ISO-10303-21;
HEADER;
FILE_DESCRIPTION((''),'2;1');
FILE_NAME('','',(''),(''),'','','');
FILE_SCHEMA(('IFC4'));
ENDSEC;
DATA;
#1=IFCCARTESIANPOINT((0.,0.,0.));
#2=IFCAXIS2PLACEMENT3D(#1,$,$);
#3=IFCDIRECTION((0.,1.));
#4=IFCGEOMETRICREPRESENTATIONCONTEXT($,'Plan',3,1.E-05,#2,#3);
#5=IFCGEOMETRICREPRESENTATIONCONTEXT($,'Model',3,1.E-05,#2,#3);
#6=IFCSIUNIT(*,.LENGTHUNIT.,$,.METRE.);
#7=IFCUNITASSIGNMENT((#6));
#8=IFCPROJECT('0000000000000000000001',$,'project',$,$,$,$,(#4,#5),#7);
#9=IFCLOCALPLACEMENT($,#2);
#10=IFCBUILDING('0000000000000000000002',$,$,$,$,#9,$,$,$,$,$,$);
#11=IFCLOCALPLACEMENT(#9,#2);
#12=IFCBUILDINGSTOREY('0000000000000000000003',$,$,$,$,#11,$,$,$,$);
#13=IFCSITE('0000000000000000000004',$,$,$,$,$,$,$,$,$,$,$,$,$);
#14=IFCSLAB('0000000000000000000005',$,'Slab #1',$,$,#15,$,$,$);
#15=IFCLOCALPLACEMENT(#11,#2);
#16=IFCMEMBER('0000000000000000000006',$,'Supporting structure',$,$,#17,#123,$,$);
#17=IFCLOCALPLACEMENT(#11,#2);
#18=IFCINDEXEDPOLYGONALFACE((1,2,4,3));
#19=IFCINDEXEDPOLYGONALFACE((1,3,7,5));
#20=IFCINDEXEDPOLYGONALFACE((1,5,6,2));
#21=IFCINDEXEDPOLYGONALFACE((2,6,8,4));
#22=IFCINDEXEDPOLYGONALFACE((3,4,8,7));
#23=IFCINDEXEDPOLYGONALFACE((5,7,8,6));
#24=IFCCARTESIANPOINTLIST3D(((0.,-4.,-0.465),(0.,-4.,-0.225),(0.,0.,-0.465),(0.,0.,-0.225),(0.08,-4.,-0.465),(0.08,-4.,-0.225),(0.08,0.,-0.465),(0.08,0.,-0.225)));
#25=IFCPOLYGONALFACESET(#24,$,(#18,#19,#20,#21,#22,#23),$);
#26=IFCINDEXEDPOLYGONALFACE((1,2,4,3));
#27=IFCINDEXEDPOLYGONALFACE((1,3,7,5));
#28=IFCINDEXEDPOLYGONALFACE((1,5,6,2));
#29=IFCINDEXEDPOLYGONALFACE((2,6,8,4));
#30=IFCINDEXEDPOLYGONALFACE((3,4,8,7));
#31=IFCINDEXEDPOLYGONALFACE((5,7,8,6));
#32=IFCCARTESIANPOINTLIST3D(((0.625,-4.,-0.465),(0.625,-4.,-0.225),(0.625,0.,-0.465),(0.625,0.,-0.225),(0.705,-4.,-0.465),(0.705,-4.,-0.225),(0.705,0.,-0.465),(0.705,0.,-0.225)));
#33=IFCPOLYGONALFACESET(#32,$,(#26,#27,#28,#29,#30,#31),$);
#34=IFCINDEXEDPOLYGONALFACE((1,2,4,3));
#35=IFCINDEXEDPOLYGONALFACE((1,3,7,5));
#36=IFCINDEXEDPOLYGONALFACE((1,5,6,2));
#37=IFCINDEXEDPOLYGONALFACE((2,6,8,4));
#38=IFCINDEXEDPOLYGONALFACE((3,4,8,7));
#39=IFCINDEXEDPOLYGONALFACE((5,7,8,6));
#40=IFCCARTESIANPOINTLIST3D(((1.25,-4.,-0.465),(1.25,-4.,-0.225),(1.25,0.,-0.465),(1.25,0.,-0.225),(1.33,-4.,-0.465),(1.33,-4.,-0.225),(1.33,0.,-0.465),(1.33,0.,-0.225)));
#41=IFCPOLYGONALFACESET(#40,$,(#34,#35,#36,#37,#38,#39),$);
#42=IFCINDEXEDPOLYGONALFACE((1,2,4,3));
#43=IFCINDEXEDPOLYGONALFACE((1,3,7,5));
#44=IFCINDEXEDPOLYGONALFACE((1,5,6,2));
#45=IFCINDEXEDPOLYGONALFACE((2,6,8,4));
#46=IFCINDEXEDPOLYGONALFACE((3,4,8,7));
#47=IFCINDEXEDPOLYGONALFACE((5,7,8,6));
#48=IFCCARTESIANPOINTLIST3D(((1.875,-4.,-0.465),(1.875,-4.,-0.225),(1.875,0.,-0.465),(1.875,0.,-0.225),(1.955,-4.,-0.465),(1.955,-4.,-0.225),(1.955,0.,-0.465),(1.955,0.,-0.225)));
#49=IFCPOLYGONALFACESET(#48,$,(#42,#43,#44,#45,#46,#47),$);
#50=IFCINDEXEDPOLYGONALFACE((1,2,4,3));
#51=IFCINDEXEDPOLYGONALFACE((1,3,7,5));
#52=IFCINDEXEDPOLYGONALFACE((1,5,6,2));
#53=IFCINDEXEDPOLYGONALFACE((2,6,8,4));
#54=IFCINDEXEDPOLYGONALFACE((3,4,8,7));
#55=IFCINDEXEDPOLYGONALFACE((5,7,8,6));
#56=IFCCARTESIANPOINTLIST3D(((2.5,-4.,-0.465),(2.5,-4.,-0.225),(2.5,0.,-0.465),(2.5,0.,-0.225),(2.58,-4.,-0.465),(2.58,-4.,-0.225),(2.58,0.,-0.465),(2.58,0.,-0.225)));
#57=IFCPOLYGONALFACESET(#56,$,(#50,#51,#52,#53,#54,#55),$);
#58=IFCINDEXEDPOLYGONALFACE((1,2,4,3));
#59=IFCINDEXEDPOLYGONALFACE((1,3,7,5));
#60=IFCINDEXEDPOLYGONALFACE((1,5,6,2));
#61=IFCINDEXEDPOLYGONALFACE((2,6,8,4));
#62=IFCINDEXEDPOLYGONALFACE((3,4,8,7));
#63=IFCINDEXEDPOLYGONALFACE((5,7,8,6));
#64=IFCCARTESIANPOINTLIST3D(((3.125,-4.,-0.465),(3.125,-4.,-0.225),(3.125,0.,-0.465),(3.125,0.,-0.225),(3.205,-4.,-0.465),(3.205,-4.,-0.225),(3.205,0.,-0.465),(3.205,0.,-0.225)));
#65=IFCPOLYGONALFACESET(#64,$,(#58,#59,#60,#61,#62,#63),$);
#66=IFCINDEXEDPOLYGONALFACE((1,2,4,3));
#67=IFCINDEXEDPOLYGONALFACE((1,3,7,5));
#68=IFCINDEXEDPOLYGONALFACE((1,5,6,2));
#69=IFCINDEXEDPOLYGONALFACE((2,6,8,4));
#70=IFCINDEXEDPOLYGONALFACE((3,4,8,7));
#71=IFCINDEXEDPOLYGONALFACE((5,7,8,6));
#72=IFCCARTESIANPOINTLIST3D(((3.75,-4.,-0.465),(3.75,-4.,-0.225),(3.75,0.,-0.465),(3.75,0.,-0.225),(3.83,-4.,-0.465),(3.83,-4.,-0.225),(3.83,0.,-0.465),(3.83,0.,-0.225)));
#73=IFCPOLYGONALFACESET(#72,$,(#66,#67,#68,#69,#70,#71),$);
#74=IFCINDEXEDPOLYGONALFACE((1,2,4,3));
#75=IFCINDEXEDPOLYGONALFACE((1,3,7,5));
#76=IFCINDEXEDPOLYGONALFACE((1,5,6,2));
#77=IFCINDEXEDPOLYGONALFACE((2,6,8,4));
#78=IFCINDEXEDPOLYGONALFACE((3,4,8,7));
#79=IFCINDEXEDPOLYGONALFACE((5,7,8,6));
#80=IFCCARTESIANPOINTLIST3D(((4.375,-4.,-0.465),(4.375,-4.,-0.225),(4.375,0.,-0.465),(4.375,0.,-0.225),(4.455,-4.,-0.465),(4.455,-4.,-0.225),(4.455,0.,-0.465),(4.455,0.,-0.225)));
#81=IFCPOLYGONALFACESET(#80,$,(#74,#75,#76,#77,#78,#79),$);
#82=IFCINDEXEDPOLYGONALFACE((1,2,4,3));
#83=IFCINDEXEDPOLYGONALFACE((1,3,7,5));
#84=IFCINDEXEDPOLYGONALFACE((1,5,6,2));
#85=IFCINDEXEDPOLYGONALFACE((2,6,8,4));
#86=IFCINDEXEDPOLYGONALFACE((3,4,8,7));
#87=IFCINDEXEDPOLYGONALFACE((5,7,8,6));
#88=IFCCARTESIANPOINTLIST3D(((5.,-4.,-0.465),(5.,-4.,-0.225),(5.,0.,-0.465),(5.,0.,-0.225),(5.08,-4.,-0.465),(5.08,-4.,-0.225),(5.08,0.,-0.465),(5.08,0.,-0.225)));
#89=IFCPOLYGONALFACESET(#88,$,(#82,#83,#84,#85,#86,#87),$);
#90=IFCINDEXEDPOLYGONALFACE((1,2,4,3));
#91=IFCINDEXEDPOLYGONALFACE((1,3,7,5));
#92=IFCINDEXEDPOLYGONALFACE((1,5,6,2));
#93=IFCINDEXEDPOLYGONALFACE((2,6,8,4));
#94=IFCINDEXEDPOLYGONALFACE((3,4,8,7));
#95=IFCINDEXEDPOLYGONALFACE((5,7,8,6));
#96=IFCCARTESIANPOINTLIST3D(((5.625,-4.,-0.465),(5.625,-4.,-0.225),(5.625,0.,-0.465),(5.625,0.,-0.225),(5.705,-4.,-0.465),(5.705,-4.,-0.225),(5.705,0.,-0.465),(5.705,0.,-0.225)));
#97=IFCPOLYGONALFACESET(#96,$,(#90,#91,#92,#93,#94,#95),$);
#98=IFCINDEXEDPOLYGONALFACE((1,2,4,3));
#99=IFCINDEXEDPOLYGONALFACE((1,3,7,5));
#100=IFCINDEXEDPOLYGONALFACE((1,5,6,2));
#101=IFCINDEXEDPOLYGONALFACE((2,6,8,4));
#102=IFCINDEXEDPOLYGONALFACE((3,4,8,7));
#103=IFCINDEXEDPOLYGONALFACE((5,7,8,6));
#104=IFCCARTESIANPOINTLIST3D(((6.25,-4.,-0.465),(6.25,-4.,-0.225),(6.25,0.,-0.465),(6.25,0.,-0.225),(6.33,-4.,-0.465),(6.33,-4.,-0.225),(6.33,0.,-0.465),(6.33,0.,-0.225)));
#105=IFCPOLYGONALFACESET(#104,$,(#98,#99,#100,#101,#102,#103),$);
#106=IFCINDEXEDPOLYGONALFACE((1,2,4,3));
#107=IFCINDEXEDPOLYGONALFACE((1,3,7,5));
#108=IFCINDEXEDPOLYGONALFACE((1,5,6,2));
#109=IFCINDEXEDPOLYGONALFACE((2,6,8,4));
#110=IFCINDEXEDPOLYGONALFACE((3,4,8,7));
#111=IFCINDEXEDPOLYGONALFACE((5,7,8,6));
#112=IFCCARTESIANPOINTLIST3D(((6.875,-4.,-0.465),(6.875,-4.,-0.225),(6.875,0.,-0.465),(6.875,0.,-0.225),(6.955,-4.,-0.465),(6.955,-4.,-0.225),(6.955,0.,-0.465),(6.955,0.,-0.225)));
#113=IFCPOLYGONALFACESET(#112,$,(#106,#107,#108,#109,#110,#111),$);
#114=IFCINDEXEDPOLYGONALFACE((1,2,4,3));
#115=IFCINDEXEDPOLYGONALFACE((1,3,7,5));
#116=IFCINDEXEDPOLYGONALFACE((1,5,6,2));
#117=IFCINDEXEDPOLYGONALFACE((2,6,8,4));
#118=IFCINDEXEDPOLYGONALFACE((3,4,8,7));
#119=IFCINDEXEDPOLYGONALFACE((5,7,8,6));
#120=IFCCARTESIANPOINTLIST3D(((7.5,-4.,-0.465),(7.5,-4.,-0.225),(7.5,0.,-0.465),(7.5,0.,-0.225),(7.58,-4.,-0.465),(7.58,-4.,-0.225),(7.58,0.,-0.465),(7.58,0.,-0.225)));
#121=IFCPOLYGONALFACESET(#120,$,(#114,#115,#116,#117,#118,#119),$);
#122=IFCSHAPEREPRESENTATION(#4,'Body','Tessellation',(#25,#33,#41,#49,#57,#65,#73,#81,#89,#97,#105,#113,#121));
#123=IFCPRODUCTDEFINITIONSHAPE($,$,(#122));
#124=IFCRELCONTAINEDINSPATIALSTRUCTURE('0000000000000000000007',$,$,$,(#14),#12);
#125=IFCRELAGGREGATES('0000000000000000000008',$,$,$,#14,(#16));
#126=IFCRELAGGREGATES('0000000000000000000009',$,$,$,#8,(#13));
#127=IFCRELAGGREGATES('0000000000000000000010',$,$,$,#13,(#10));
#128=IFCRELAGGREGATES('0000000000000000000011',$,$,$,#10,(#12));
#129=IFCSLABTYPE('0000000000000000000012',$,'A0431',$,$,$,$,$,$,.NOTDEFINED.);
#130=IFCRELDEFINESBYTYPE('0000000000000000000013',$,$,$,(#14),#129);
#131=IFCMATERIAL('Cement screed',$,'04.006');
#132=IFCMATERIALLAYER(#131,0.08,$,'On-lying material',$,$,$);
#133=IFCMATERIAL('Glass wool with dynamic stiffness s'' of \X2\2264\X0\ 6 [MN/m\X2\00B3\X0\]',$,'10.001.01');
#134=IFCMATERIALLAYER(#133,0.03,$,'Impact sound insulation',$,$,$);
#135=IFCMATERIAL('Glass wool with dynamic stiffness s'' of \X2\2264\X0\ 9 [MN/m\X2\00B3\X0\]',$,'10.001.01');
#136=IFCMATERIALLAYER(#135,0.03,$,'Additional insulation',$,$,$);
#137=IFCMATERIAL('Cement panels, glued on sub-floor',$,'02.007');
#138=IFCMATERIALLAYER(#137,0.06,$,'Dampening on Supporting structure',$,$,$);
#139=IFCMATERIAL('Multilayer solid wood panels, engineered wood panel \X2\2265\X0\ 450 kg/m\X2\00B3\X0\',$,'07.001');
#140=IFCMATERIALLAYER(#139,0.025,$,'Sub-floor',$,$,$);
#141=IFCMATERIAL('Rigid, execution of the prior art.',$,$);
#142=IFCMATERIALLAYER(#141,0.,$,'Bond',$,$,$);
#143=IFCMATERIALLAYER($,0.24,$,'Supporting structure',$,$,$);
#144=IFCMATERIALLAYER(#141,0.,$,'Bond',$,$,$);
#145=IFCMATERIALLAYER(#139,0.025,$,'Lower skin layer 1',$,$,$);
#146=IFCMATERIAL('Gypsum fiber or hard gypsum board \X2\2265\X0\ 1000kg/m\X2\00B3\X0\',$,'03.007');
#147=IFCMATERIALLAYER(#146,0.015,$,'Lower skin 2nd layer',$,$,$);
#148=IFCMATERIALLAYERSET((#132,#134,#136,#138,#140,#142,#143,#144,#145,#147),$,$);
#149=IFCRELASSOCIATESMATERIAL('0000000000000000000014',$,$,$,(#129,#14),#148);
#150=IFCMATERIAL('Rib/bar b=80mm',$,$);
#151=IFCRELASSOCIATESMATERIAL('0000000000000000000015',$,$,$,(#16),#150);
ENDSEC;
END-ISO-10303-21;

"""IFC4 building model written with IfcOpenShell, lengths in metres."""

from ifc_helpers import new_model, si_unit, direction, frame, frame_2d, origin, place, context, project, spatial, rectangle, extrude, material, layer, layer_set, type_object, element, aggregate, save


model = new_model("IFC4")

# Units and contexts
plan_context = context("Plan", 3, precision=1e-05, world=origin(), true_north=direction((0.0, 1.0)))
model_context = context("Model", 3, precision=1e-05, world=origin(), true_north=direction((0.0, 1.0)))
ifc_project = project(units=[si_unit("LENGTHUNIT", "METRE")], contexts=[plan_context, model_context])

# Site, building, storey
site = spatial("IfcSite", under=ifc_project)
building_placement = place(None, origin())
building = spatial("IfcBuilding", under=site, at=building_placement)
storey_placement = place(building_placement, origin())
storey = spatial("IfcBuildingStorey", under=building, at=storey_placement)

# Slab, member
ifc_material_1 = material(Name="Cement screed", Category="04.006")
ifc_layer_1 = layer(ifc_material_1, 0.08, Name="On-lying material")
ifc_material_2 = material(Name="Glass wool with dynamic stiffness s' of ≤ 6 [MN/m³]", Category="10.001.01")
ifc_layer_2 = layer(ifc_material_2, 0.03, Name="Impact sound insulation")
ifc_material_3 = material(Name="Glass wool with dynamic stiffness s' of ≤ 9 [MN/m³]", Category="10.001.01")
ifc_layer_3 = layer(ifc_material_3, 0.03, Name="Additional insulation")
ifc_material_4 = material(Name="Cement panels, glued on sub-floor", Category="02.007")
ifc_layer_4 = layer(ifc_material_4, 0.06, Name="Dampening on Supporting structure")
ifc_material_5 = material(Name="Multilayer solid wood panels, engineered wood panel ≥ 450 kg/m³", Category="07.001")
ifc_layer_5 = layer(ifc_material_5, 0.025, Name="Sub-floor")
ifc_material_6 = material(Name="Rigid, execution of the prior art.")
ifc_layer_6 = layer(ifc_material_6, 0.0, Name="Bond")
ifc_layer_7 = layer(None, 0.24, Name="Supporting structure")
ifc_layer_8 = layer(ifc_material_6, 0.0, Name="Bond")
ifc_layer_9 = layer(ifc_material_5, 0.025, Name="Lower skin layer 1")
ifc_material_7 = material(Name="Gypsum fiber or hard gypsum board ≥ 1000kg/m³", Category="03.007")
ifc_layer_10 = layer(ifc_material_7, 0.015, Name="Lower skin 2nd layer")
ifc_layer_set = layer_set([ifc_layer_1, ifc_layer_2, ifc_layer_3, ifc_layer_4, ifc_layer_5, ifc_layer_6, ifc_layer_7, ifc_layer_8, ifc_layer_9, ifc_layer_10])
slab_type = type_object("IfcSlabType", Name="A0431", PredefinedType="NOTDEFINED", material=ifc_layer_set)
slab_placement = place(None, frame((0.0, 0.0, 0.0), z_axis=(0.0, 0.0, -1.0), x_axis=(1.0, 0.0, 0.0)))
slab = element("IfcSlab", 1, at=slab_placement, inside=storey, type_object=slab_type, material=ifc_layer_set, Name="Slab #1")
ifc_material_8 = material(Name="Rib/bar b=80mm")
member_1_placement = place(slab_placement, origin())
member_1 = element("IfcMember", 2, at=member_1_placement, material=ifc_material_8, Name="Supporting structure", context=plan_context, shape_type="SweptSolid", body=[
    extrude(rectangle(XDim=0.08, YDim=0.24, at=frame_2d((0.04, 0.12), x_axis=(1.0, 0.0))), frame((0.0, 4.0, 0.225), z_axis=(0.0, -1.0, 0.0), x_axis=(1.0, 0.0, 0.0)), (0.0, 0.0, 1.0), 4.0),
    extrude(rectangle(XDim=0.08, YDim=0.24, at=frame_2d((0.04, 0.12), x_axis=(1.0, 0.0))), frame((0.625, 4.0, 0.225), z_axis=(0.0, -1.0, 0.0), x_axis=(1.0, 0.0, 0.0)), (0.0, 0.0, 1.0), 4.0),
    extrude(rectangle(XDim=0.08, YDim=0.24, at=frame_2d((0.04, 0.12), x_axis=(1.0, 0.0))), frame((1.25, 4.0, 0.225), z_axis=(0.0, -1.0, 0.0), x_axis=(1.0, 0.0, 0.0)), (0.0, 0.0, 1.0), 4.0),
    extrude(rectangle(XDim=0.08, YDim=0.24, at=frame_2d((0.04, 0.12), x_axis=(1.0, 0.0))), frame((1.875, 4.0, 0.225), z_axis=(0.0, -1.0, 0.0), x_axis=(1.0, 0.0, 0.0)), (0.0, 0.0, 1.0), 4.0),
    extrude(rectangle(XDim=0.08, YDim=0.24, at=frame_2d((0.04, 0.12), x_axis=(1.0, 0.0))), frame((2.5, 4.0, 0.225), z_axis=(0.0, -1.0, 0.0), x_axis=(1.0, 0.0, 0.0)), (0.0, 0.0, 1.0), 4.0),
    extrude(rectangle(XDim=0.08, YDim=0.24, at=frame_2d((0.04, 0.12), x_axis=(1.0, 0.0))), frame((3.125, 4.0, 0.225), z_axis=(0.0, -1.0, 0.0), x_axis=(1.0, 0.0, 0.0)), (0.0, 0.0, 1.0), 4.0),
    extrude(rectangle(XDim=0.08, YDim=0.24, at=frame_2d((0.04, 0.12), x_axis=(1.0, 0.0))), frame((3.75, 4.0, 0.225), z_axis=(0.0, -1.0, 0.0), x_axis=(1.0, 0.0, 0.0)), (0.0, 0.0, 1.0), 4.0),
    extrude(rectangle(XDim=0.08, YDim=0.24, at=frame_2d((0.04, 0.12), x_axis=(1.0, 0.0))), frame((4.375, 4.0, 0.225), z_axis=(0.0, -1.0, 0.0), x_axis=(1.0, 0.0, 0.0)), (0.0, 0.0, 1.0), 4.0),
    extrude(rectangle(XDim=0.08, YDim=0.24, at=frame_2d((0.04, 0.12), x_axis=(1.0, 0.0))), frame((5.0, 4.0, 0.225), z_axis=(0.0, -1.0, 0.0), x_axis=(1.0, 0.0, 0.0)), (0.0, 0.0, 1.0), 4.0),
    extrude(rectangle(XDim=0.08, YDim=0.24, at=frame_2d((0.04, 0.12), x_axis=(1.0, 0.0))), frame((5.625, 4.0, 0.225), z_axis=(0.0, -1.0, 0.0), x_axis=(1.0, 0.0, 0.0)), (0.0, 0.0, 1.0), 4.0),
    extrude(rectangle(XDim=0.08, YDim=0.24, at=frame_2d((0.04, 0.12), x_axis=(1.0, 0.0))), frame((6.25, 4.0, 0.225), z_axis=(0.0, -1.0, 0.0), x_axis=(1.0, 0.0, 0.0)), (0.0, 0.0, 1.0), 4.0),
    extrude(rectangle(XDim=0.08, YDim=0.24, at=frame_2d((0.04, 0.12), x_axis=(1.0, 0.0))), frame((6.875, 4.0, 0.225), z_axis=(0.0, -1.0, 0.0), x_axis=(1.0, 0.0, 0.0)), (0.0, 0.0, 1.0), 4.0),
    extrude(rectangle(XDim=0.08, YDim=0.24, at=frame_2d((0.04, 0.12), x_axis=(1.0, 0.0))), frame((7.5, 4.0, 0.225), z_axis=(0.0, -1.0, 0.0), x_axis=(1.0, 0.0, 0.0)), (0.0, 0.0, 1.0), 4.0),
])
aggregate(slab, [member_1])

save(model, "model.ifc")
